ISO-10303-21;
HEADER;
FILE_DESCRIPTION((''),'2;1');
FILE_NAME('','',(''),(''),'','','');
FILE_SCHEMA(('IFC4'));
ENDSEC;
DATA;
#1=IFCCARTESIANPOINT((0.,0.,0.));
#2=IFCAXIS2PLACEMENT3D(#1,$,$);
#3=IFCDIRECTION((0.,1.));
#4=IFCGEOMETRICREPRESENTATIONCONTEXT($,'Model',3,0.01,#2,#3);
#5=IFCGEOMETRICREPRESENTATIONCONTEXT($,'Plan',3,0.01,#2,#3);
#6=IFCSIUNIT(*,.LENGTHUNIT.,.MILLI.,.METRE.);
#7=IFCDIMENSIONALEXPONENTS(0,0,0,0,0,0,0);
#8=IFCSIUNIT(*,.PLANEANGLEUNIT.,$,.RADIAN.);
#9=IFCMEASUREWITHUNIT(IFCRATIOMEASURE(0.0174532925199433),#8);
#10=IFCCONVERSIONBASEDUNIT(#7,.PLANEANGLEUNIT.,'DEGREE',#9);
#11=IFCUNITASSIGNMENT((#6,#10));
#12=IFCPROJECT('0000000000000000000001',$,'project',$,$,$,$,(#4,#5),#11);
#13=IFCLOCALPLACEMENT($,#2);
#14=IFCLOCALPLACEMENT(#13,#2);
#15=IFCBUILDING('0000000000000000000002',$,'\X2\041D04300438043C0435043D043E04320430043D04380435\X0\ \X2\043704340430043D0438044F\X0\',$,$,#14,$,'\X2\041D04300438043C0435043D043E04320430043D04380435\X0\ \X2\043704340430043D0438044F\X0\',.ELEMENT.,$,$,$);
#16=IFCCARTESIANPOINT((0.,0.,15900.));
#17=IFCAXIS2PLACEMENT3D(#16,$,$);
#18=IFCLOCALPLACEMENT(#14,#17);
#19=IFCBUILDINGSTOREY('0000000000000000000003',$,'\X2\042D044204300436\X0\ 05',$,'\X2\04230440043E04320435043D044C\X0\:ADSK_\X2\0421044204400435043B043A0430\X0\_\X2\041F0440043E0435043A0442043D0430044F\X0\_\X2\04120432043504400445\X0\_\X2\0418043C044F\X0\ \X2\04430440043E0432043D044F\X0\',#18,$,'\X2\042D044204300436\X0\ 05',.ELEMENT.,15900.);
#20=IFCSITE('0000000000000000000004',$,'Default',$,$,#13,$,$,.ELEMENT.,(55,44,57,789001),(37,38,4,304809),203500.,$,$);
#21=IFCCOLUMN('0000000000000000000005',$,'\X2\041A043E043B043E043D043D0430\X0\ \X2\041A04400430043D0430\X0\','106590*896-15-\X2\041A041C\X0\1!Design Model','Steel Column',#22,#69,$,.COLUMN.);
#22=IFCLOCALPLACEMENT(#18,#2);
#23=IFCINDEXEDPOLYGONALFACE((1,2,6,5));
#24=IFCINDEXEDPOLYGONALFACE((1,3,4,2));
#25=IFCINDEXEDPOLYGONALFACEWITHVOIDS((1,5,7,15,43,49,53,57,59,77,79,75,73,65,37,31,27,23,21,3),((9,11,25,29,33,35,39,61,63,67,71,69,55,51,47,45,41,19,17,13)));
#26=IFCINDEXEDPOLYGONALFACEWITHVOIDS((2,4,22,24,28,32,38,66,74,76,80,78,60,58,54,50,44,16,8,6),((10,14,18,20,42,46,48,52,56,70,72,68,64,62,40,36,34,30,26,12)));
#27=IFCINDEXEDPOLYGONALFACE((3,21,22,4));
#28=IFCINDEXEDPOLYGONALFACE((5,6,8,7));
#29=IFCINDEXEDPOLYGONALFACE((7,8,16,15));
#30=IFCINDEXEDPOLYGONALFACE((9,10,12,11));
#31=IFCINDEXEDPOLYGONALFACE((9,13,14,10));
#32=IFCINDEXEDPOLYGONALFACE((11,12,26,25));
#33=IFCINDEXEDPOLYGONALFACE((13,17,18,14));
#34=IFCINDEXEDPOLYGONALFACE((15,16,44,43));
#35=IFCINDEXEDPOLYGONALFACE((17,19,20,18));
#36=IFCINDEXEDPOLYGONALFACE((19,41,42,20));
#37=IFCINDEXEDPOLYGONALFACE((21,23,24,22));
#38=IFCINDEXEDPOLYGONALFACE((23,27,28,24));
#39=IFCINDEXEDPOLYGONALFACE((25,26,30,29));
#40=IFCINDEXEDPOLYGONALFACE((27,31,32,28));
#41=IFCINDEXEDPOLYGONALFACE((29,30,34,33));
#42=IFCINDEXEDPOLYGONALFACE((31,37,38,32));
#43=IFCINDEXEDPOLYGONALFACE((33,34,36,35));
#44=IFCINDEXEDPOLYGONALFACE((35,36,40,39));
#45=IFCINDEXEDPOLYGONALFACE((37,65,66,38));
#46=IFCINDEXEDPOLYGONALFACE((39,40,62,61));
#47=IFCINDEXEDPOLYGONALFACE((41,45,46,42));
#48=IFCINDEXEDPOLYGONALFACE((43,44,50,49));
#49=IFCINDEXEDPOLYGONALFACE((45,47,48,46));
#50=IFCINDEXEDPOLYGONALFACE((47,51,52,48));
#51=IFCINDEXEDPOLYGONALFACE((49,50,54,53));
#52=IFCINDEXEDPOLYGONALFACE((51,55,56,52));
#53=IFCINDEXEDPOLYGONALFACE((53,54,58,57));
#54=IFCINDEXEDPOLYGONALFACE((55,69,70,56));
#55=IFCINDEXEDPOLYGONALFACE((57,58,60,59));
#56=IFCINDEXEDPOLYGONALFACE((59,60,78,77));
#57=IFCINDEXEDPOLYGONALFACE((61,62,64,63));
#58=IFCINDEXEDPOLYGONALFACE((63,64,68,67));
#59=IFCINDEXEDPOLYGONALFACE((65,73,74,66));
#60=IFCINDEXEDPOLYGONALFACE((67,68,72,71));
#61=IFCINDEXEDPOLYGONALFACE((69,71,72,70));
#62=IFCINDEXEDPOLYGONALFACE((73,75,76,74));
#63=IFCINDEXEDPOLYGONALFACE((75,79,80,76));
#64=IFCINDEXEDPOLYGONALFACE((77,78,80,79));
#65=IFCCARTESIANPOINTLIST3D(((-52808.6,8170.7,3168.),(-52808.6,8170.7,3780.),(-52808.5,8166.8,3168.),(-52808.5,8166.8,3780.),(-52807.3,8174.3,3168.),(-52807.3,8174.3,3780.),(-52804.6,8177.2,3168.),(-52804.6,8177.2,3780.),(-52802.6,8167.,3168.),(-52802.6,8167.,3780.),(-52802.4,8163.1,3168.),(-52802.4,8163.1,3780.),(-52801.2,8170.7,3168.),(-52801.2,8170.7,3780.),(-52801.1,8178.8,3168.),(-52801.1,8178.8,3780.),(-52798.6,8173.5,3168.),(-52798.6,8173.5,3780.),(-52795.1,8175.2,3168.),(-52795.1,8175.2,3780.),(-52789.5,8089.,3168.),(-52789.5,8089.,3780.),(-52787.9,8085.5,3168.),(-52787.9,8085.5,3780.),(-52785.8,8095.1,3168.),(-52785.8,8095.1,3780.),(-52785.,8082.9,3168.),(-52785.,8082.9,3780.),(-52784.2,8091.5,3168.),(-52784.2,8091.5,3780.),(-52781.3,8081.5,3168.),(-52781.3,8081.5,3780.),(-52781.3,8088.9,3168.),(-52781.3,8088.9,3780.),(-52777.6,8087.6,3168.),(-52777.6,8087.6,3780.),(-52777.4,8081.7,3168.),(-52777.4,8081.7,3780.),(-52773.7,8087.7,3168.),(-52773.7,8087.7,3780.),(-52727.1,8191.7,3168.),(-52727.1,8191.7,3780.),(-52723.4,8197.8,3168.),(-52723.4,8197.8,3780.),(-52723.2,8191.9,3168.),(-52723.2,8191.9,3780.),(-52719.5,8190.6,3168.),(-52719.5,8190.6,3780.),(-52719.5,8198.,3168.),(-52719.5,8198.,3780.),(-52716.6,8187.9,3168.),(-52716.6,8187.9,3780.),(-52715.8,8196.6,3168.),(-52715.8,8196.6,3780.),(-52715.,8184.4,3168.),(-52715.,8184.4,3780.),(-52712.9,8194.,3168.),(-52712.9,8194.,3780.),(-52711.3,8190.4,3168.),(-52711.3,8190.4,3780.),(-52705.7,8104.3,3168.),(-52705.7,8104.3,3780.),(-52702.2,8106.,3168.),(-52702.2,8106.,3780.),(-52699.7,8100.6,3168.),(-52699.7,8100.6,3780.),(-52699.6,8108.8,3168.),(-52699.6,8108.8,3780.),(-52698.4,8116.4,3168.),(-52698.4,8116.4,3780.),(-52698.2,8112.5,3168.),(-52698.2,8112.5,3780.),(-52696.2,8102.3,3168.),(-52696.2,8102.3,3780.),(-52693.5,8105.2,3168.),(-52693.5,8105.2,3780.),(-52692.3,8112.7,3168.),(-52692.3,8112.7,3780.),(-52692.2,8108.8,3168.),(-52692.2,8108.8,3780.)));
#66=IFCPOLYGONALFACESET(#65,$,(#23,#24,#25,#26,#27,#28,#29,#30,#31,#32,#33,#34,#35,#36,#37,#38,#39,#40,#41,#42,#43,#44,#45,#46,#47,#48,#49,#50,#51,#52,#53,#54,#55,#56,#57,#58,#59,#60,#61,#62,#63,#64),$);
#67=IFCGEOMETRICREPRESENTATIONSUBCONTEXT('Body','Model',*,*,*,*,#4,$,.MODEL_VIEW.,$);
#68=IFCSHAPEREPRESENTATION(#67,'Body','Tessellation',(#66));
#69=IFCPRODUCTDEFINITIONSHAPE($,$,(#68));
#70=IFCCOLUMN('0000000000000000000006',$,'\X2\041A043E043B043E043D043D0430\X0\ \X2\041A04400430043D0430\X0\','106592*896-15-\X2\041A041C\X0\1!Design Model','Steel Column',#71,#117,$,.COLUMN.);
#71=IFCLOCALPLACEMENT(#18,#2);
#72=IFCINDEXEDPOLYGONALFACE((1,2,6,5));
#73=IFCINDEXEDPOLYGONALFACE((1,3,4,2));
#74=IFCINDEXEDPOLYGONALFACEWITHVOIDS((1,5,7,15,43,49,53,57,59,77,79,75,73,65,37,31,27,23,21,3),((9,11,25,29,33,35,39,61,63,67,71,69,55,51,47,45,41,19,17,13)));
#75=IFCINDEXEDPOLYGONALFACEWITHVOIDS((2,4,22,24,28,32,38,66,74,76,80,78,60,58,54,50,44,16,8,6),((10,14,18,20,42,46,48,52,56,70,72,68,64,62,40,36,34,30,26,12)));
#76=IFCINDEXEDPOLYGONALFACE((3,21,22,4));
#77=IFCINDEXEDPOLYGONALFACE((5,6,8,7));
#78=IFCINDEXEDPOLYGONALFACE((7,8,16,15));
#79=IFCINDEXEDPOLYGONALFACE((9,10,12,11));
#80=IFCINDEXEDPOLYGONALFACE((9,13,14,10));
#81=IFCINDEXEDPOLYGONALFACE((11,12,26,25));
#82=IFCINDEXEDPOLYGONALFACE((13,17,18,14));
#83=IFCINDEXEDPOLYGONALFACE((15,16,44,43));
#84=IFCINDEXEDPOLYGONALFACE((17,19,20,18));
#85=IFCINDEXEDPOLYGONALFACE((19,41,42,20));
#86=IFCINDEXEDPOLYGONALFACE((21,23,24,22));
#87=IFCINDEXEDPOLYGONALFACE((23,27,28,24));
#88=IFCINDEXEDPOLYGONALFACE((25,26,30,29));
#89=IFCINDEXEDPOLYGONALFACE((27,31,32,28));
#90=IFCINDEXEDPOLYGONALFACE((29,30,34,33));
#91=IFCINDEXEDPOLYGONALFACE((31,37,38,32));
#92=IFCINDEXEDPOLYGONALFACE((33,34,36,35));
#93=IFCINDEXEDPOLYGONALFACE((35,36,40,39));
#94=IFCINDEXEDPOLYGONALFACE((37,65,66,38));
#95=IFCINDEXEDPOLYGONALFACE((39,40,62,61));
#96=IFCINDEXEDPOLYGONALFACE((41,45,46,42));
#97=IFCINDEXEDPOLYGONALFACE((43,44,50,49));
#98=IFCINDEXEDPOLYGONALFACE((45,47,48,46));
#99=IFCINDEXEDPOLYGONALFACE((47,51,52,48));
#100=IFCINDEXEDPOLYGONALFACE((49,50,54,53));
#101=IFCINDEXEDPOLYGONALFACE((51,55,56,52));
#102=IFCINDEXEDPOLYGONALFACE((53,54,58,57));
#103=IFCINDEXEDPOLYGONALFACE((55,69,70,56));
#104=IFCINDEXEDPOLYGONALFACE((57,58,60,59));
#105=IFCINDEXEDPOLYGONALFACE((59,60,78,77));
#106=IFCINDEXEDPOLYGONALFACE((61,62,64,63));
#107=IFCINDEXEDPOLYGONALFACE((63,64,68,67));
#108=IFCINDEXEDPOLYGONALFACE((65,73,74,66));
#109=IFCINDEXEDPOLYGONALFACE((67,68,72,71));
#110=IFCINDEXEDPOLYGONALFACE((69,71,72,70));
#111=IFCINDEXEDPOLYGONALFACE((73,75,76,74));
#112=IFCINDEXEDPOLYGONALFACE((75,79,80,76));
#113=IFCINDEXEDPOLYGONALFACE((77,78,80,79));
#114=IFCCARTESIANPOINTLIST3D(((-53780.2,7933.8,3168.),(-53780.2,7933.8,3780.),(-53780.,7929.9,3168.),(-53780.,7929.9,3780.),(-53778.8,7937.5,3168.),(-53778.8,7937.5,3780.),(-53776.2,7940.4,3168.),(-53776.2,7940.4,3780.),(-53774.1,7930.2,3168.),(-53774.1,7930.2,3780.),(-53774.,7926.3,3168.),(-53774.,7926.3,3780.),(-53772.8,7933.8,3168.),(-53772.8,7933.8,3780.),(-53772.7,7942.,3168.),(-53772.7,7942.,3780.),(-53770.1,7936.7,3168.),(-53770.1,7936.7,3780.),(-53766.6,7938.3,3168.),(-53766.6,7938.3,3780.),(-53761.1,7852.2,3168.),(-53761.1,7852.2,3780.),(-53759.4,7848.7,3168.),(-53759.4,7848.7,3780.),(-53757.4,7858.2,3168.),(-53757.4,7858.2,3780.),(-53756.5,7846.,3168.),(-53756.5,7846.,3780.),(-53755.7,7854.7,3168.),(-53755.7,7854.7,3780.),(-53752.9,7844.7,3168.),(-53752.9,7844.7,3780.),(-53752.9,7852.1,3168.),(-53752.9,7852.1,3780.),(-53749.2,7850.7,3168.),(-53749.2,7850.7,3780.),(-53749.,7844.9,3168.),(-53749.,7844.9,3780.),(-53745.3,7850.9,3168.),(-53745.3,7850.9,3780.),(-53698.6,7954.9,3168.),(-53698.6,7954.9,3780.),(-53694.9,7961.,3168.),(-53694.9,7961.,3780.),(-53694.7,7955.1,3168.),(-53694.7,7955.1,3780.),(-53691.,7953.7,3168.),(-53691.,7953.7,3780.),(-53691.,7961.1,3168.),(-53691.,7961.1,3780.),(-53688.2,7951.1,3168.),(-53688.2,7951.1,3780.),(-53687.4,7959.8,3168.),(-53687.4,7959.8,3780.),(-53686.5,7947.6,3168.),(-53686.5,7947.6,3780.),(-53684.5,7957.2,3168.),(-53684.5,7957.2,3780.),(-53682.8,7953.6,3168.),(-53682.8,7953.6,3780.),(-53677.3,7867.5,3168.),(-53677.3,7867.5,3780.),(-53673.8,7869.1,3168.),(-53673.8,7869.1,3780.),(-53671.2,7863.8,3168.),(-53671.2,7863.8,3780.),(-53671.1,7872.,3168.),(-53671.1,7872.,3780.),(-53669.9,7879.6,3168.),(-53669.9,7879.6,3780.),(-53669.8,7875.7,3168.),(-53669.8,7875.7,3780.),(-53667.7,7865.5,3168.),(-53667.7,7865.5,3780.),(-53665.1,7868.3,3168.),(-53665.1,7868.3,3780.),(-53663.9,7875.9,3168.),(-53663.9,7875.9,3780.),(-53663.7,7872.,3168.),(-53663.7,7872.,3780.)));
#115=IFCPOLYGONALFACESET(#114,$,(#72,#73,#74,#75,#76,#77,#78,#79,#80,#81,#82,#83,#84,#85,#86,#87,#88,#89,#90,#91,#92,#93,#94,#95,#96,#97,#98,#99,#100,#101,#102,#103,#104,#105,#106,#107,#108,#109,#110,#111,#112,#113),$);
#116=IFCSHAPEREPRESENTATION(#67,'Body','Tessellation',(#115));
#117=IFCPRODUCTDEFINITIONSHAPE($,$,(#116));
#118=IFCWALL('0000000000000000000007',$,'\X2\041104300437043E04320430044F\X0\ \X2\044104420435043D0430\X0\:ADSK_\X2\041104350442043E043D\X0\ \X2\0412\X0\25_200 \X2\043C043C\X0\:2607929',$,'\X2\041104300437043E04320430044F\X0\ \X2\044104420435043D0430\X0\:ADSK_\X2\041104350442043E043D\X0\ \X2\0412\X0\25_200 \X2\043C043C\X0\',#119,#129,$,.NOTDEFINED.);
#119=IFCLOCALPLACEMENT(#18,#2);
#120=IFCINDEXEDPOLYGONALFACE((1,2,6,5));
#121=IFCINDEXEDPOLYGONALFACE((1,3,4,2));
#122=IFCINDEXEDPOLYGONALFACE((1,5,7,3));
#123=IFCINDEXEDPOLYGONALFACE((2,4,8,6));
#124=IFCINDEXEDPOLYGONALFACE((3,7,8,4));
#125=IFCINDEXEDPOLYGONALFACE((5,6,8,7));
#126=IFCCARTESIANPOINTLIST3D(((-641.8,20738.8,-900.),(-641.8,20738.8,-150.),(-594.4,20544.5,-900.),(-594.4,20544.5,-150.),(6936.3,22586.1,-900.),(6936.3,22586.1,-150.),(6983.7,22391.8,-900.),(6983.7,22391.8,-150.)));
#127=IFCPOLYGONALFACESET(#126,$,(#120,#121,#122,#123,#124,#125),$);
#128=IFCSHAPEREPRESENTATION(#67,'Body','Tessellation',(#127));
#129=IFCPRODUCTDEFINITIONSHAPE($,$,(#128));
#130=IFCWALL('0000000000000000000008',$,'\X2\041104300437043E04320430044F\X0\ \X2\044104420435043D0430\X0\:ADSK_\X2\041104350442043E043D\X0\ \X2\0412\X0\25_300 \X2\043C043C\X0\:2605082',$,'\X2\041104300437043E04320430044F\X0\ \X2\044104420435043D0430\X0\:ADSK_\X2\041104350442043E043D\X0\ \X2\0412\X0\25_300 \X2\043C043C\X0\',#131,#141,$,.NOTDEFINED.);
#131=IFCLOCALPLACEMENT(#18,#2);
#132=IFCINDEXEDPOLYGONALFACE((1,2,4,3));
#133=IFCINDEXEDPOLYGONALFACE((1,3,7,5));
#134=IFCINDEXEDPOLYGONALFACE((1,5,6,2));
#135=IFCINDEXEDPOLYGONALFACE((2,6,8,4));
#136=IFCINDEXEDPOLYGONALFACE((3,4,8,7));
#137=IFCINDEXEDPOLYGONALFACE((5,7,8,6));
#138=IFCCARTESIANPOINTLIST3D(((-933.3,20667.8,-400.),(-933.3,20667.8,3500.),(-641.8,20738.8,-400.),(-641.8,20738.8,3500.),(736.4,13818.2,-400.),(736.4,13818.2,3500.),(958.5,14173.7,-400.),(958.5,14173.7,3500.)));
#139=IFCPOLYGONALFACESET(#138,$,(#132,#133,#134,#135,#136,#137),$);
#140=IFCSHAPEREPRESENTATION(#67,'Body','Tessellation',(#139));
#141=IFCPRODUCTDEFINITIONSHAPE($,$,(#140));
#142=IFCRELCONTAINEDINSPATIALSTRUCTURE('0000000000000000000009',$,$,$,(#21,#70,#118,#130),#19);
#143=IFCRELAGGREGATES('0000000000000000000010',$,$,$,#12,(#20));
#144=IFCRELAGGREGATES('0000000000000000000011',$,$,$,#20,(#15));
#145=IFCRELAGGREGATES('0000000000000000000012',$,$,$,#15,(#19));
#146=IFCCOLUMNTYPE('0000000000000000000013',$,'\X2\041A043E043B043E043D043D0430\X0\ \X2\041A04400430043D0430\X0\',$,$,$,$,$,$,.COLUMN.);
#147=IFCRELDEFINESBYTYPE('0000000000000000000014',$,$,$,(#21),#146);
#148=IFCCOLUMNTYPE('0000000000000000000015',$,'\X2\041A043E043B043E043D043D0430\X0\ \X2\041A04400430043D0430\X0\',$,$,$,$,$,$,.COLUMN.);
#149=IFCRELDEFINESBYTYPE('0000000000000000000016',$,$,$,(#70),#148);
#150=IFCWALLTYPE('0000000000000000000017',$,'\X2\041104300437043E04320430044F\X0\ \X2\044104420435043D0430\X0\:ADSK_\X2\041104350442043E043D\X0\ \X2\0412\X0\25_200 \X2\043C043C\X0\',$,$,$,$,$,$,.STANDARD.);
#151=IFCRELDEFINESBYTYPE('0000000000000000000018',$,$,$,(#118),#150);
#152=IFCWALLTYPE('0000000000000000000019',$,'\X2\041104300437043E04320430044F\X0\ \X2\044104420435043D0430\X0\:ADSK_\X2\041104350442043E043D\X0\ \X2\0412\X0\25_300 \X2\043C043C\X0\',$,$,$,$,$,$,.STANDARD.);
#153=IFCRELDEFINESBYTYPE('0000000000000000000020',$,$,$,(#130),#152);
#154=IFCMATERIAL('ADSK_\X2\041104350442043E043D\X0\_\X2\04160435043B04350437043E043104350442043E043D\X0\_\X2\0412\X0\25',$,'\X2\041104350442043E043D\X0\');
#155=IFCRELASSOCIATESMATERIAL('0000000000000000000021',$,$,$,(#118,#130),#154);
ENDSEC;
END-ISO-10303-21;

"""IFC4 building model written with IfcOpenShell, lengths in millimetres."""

from ifc_helpers import new_model, entity, si_unit, converted_unit, direction, frame, origin, place, context, subcontext, project, spatial, indexed_curve, outline, extrude, material, type_object, element, save


model = new_model("IFC4")

# Units and contexts
model_context = context("Model", 3, precision=0.01, world=origin(), true_north=direction((0.0, 1.0)))
plan_context = context("Plan", 3, precision=0.01, world=origin(), true_north=direction((0.0, 1.0)))
body_context = subcontext(model_context, "Body", "Model", "MODEL_VIEW")
ifc_project = project(units=[si_unit("LENGTHUNIT", "METRE", prefix="MILLI"), converted_unit("PLANEANGLEUNIT", "DEGREE", entity("IfcRatioMeasure", 0.0174532925199433), si_unit("PLANEANGLEUNIT", "RADIAN"), dimensions=[0, 0, 0, 0, 0, 0, 0])], contexts=[model_context, plan_context])

# Site, building, storey
site_placement = place(None, origin())
site = spatial("IfcSite", under=ifc_project, at=site_placement, Name="Default", CompositionType="ELEMENT", RefLatitude=(55, 44, 57, 789001), RefLongitude=(37, 38, 4, 304809), RefElevation=203500.0)
building_placement = place(site_placement, origin())
building = spatial("IfcBuilding", under=site, at=building_placement, Name="Наименование здания", LongName="Наименование здания", CompositionType="ELEMENT")
storey_placement = place(building_placement, frame((0.0, 0.0, 15900.0)))
storey = spatial("IfcBuildingStorey", under=building, at=storey_placement, Name="Этаж 05", ObjectType="Уровень:ADSK_Стрелка_Проектная_Вверх_Имя уровня", LongName="Этаж 05", CompositionType="ELEMENT", Elevation=15900.0)

# Columns
placement = place(storey_placement, origin())
column_type_1 = type_object("IfcColumnType", Name="Колонна Крана", PredefinedType="COLUMN")
element("IfcColumn", 1, at=placement, inside=storey, type_object=column_type_1, Name="Колонна Крана", Description="106590*896-15-КМ1!Design Model", ObjectType="Steel Column", PredefinedType="COLUMN", context=body_context, shape_type="SweptSolid", body=[
    extrude(outline(indexed_curve([(29.5, -56.8), (33.4, -56.8), (37.0, -55.3), (39.7, -52.6), (41.2, -49.0), (56.8, 29.5), (56.8, 33.4), (55.3, 37.0), (52.6, 39.7), (49.0, 41.2), (-29.5, 56.8), (-33.4, 56.8), (-37.0, 55.3), (-39.7, 52.6), (-41.2, 49.0), (-56.8, -29.5), (-56.8, -33.4), (-55.3, -37.0), (-52.6, -39.7), (-49.0, -41.2), (29.5, -56.8)], self_intersect=False), holes=[indexed_curve([(-43.1, -37.3), (-46.7, -35.8), (-49.5, -33.1), (-51.0, -29.5), (-51.0, -25.5), (-37.3, 43.1), (-35.8, 46.7), (-33.1, 49.5), (-29.5, 51.0), (-25.5, 51.0), (43.1, 37.3), (46.7, 35.8), (49.5, 33.1), (51.0, 29.5), (51.0, 25.5), (37.3, -43.1), (35.8, -46.7), (33.1, -49.5), (29.5, -51.0), (25.5, -51.0), (-43.1, -37.3)], self_intersect=False)]), frame((-52750.4, 8139.7, 3168.0), z_axis=(0.0, 0.0, 1.0), x_axis=(0.906681, 0.421816, 0.0)), (0.0, 0.0, 1.0), 612.0),
])
column_type_2 = type_object("IfcColumnType", Name="Колонна Крана", PredefinedType="COLUMN")
element("IfcColumn", 2, at=placement, inside=storey, type_object=column_type_2, Name="Колонна Крана", Description="106592*896-15-КМ1!Design Model", ObjectType="Steel Column", PredefinedType="COLUMN", context=body_context, shape_type="SweptSolid", body=[
    extrude(outline(indexed_curve([(29.5, -56.8), (33.4, -56.8), (37.0, -55.3), (39.7, -52.6), (41.2, -49.0), (56.8, 29.5), (56.8, 33.4), (55.3, 37.0), (52.6, 39.7), (49.0, 41.2), (-29.5, 56.8), (-33.4, 56.8), (-37.0, 55.3), (-39.7, 52.6), (-41.2, 49.0), (-56.8, -29.5), (-56.8, -33.4), (-55.3, -37.0), (-52.6, -39.7), (-49.0, -41.2), (29.5, -56.8)], self_intersect=False), holes=[indexed_curve([(-43.1, -37.3), (-46.7, -35.8), (-49.5, -33.1), (-51.0, -29.5), (-51.0, -25.5), (-37.3, 43.1), (-35.8, 46.7), (-33.1, 49.5), (-29.5, 51.0), (-25.5, 51.0), (43.1, 37.3), (46.7, 35.8), (49.5, 33.1), (51.0, 29.5), (51.0, 25.5), (37.3, -43.1), (35.8, -46.7), (33.1, -49.5), (29.5, -51.0), (25.5, -51.0), (-43.1, -37.3)], self_intersect=False)]), frame((-53721.9, 7902.9, 3168.0), z_axis=(0.0, 0.0, 1.0), x_axis=(0.906681, 0.421816, 0.0)), (0.0, 0.0, 1.0), 612.0),
])

# Walls
ifc_material = material(Name="ADSK_Бетон_Железобетон_В25", Category="Бетон")
wall_type_1 = type_object("IfcWallType", Name="Базовая стена:ADSK_Бетон В25_200 мм", PredefinedType="STANDARD")
wall_1_placement = place(storey_placement, frame((-618.1, 20641.7, -900.0), z_axis=(0.0, 0.0, 1.0), x_axis=(0.971552, 0.236826, 0.0)))
element("IfcWall", 3, at=wall_1_placement, inside=storey, type_object=wall_type_1, material=ifc_material, Name="Базовая стена:ADSK_Бетон В25_200 мм:2607929", ObjectType="Базовая стена:ADSK_Бетон В25_200 мм", PredefinedType="NOTDEFINED", context=body_context, shape_type="SweptSolid", body=[
    extrude(outline(indexed_curve([(7800.0, 100.0), (0.0, 100.0), (0.0, -100.0), (7800.0, -100.0), (7800.0, 100.0)], self_intersect=False)), origin(), (0.0, 0.0, 1.0), 750.0),
])
wall_type_2 = type_object("IfcWallType", Name="Базовая стена:ADSK_Бетон В25_300 мм", PredefinedType="STANDARD")
wall_2_placement = place(storey_placement, frame((-787.5, 20703.3, -400.0), z_axis=(0.0, 0.0, 1.0), x_axis=(0.236826, -0.971552, 0.0)))
element("IfcWall", 4, at=wall_2_placement, inside=storey, type_object=wall_type_2, material=ifc_material, Name="Базовая стена:ADSK_Бетон В25_300 мм:2605082", ObjectType="Базовая стена:ADSK_Бетон В25_300 мм", PredefinedType="NOTDEFINED", context=body_context, shape_type="SweptSolid", body=[
    extrude(outline(indexed_curve([(7050.2, -150.0), (6757.4, 150.0), (0.0, 150.0), (0.0, -150.0), (7050.2, -150.0)], self_intersect=False)), origin(), (0.0, 0.0, 1.0), 3900.0),
])

save(model, "model.ifc")
